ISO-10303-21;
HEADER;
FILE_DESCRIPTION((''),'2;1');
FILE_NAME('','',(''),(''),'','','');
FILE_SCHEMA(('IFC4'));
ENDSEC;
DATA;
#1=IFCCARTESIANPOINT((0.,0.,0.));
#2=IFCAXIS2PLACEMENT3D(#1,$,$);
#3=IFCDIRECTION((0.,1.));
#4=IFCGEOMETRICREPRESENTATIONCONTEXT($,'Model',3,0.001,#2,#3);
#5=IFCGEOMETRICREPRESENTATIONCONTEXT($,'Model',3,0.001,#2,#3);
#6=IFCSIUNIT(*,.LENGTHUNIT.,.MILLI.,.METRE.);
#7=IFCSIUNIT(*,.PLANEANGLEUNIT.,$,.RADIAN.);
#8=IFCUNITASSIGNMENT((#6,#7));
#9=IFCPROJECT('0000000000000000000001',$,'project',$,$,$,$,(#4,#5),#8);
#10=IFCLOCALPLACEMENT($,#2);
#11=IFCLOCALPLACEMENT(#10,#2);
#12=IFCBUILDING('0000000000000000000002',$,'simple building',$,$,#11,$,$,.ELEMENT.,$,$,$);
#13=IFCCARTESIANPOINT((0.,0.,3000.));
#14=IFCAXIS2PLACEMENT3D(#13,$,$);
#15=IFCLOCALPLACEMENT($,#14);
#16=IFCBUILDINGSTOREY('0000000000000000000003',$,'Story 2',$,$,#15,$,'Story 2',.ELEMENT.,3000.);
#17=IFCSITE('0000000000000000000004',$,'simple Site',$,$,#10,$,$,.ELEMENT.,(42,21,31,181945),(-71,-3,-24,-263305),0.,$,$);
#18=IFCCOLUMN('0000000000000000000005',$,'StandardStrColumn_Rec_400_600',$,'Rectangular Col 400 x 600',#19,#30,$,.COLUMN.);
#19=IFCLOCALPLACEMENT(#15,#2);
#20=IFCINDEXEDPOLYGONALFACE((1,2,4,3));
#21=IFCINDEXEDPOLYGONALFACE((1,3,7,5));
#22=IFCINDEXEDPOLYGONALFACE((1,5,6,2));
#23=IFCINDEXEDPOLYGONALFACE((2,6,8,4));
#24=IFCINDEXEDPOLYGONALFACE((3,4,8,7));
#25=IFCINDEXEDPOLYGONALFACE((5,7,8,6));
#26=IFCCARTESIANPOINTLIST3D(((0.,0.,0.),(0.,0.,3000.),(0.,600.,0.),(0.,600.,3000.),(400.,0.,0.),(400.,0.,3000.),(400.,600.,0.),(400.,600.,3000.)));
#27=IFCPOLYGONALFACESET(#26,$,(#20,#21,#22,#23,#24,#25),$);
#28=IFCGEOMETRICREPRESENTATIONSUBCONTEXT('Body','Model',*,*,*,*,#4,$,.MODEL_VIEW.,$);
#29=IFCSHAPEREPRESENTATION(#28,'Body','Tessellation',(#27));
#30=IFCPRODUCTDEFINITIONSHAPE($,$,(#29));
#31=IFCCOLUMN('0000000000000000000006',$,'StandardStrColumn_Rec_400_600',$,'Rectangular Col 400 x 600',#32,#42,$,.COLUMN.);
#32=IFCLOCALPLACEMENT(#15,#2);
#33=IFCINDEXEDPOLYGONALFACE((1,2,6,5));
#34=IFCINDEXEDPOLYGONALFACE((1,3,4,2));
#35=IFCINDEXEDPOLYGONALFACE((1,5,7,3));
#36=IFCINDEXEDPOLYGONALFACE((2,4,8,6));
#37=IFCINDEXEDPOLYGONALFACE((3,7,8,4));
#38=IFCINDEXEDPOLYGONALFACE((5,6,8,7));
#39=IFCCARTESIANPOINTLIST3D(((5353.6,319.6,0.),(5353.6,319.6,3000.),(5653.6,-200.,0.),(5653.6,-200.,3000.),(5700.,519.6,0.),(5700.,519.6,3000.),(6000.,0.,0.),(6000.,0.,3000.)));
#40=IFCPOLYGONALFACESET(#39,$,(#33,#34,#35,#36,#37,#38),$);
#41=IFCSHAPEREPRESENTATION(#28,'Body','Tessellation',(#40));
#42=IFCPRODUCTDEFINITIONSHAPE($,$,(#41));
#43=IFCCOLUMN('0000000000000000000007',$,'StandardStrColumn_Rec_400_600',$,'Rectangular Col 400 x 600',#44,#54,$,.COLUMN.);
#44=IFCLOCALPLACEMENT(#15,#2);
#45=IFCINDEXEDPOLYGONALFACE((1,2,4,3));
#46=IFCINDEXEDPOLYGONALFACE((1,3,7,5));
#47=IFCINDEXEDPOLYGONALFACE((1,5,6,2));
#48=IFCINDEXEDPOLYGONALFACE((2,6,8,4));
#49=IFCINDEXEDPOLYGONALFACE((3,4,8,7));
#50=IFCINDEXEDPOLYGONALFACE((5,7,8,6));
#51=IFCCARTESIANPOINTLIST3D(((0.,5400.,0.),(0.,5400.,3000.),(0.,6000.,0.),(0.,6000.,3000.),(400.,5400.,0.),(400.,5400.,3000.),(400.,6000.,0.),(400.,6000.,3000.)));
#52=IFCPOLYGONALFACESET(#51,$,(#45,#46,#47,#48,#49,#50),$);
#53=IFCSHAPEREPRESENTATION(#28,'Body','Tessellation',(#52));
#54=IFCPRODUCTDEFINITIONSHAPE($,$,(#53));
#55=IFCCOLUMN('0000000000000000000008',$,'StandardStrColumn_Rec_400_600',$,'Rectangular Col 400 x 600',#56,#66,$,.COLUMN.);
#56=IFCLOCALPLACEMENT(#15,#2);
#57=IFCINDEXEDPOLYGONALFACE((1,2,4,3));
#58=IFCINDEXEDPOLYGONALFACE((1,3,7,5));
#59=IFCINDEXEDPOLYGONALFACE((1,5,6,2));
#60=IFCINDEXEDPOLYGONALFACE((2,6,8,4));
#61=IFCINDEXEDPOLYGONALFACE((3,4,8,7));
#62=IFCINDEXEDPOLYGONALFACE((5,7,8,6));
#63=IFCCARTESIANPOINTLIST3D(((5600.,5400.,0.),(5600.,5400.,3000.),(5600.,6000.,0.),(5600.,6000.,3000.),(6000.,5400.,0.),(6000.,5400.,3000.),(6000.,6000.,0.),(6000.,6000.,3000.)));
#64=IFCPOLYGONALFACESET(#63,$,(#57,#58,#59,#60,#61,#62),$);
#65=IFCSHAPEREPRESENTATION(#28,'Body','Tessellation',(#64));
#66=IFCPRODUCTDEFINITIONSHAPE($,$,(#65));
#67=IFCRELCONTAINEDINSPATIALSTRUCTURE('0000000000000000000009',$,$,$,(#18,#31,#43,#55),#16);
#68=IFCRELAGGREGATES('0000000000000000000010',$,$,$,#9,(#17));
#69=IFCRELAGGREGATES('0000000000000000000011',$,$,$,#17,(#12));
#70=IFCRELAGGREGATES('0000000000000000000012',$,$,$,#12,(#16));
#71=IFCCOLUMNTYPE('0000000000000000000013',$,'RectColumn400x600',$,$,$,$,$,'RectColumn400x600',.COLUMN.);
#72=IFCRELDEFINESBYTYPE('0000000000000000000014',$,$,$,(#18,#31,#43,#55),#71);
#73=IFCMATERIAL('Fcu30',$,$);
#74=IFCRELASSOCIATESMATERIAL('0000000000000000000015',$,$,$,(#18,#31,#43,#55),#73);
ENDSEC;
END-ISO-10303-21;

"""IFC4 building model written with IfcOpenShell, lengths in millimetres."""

from ifc_helpers import new_model, si_unit, direction, frame, origin, origin_with_axes, origin_2d_with_axis, place, context, subcontext, project, spatial, rectangle, extrude, material, material_profile, profile_set, profile_usage, type_object, element, save


model = new_model("IFC4")

# Units and contexts
model_context_1 = context("Model", 3, precision=0.001, world=origin(), true_north=direction((0.0, 1.0)))
model_context_2 = context("Model", 3, precision=0.001, world=origin(), true_north=direction((0.0, 1.0)))
body_context = subcontext(model_context_1, "Body", "Model", "MODEL_VIEW")
ifc_project = project(units=[si_unit("LENGTHUNIT", "METRE", prefix="MILLI"), si_unit("PLANEANGLEUNIT", "RADIAN")], contexts=[model_context_1, model_context_2])

# Site, building, storey
site_placement = place(None, origin())
site = spatial("IfcSite", under=ifc_project, at=site_placement, Name="simple Site", CompositionType="ELEMENT", RefLatitude=(42, 21, 31, 181945), RefLongitude=(-71, -3, -24, -263305), RefElevation=0.0)
building_placement = place(site_placement, origin())
building = spatial("IfcBuilding", under=site, at=building_placement, Name="simple building", CompositionType="ELEMENT")
storey_placement = place(None, frame((0.0, 0.0, 3000.0)))
storey = spatial("IfcBuildingStorey", under=building, at=storey_placement, Name="Story 2", LongName="Story 2", CompositionType="ELEMENT", Elevation=3000.0)

# Columns
ifc_material = material(Name="Fcu30")
ifc_material_profile = material_profile(ifc_material, rectangle(XDim=400.0, YDim=600.0, at=origin_2d_with_axis()))
ifc_profile_set = profile_set([ifc_material_profile])
ifc_profile_usage_1 = profile_usage(ifc_profile_set, cardinal=7)
column_type = type_object("IfcColumnType", Name="RectColumn400x600", ElementType="RectColumn400x600", PredefinedType="COLUMN")
column_1_placement = place(None, frame((200.0, 300.0, 3000.0), z_axis=(0.0, 0.0, 1.0), x_axis=(1.0, 0.0, 0.0)))
element("IfcColumn", 1, at=column_1_placement, inside=storey, type_object=column_type, material=ifc_profile_usage_1, Name="StandardStrColumn_Rec_400_600", ObjectType="Rectangular Col 400 x 600", PredefinedType="COLUMN", context=body_context, shape_type="SweptSolid", body=[
    extrude(rectangle(XDim=400.0, YDim=600.0, at=origin_2d_with_axis()), origin_with_axes(), (0.0, 0.0, 1.0), 3000.0),
])
ifc_profile_usage_2 = profile_usage(ifc_profile_set, cardinal=9)
column_2_placement = place(None, frame((5676.8, 159.8, 3000.0), z_axis=(0.0, 0.0, 1.0), x_axis=(0.866025, 0.5, 0.0)))
element("IfcColumn", 2, at=column_2_placement, inside=storey, type_object=column_type, material=ifc_profile_usage_2, Name="StandardStrColumn_Rec_400_600", ObjectType="Rectangular Col 400 x 600", PredefinedType="COLUMN", context=body_context, shape_type="SweptSolid", body=[
    extrude(rectangle(XDim=400.0, YDim=600.0, at=origin_2d_with_axis()), origin_with_axes(), (0.0, 0.0, 1.0), 3000.0),
])
ifc_profile_usage_3 = profile_usage(ifc_profile_set, cardinal=1)
column_3_placement = place(None, frame((200.0, 5700.0, 3000.0), z_axis=(0.0, 0.0, 1.0), x_axis=(1.0, 0.0, 0.0)))
element("IfcColumn", 3, at=column_3_placement, inside=storey, type_object=column_type, material=ifc_profile_usage_3, Name="StandardStrColumn_Rec_400_600", ObjectType="Rectangular Col 400 x 600", PredefinedType="COLUMN", context=body_context, shape_type="SweptSolid", body=[
    extrude(rectangle(XDim=400.0, YDim=600.0, at=origin_2d_with_axis()), origin_with_axes(), (0.0, 0.0, 1.0), 3000.0),
])
ifc_profile_usage_4 = profile_usage(ifc_profile_set, cardinal=3)
column_4_placement = place(None, frame((5800.0, 5700.0, 3000.0), z_axis=(0.0, 0.0, 1.0), x_axis=(1.0, 0.0, 0.0)))
element("IfcColumn", 4, at=column_4_placement, inside=storey, type_object=column_type, material=ifc_profile_usage_4, Name="StandardStrColumn_Rec_400_600", ObjectType="Rectangular Col 400 x 600", PredefinedType="COLUMN", context=body_context, shape_type="SweptSolid", body=[
    extrude(rectangle(XDim=400.0, YDim=600.0, at=origin_2d_with_axis()), origin_with_axes(), (0.0, 0.0, 1.0), 3000.0),
])

save(model, "model.ifc")
